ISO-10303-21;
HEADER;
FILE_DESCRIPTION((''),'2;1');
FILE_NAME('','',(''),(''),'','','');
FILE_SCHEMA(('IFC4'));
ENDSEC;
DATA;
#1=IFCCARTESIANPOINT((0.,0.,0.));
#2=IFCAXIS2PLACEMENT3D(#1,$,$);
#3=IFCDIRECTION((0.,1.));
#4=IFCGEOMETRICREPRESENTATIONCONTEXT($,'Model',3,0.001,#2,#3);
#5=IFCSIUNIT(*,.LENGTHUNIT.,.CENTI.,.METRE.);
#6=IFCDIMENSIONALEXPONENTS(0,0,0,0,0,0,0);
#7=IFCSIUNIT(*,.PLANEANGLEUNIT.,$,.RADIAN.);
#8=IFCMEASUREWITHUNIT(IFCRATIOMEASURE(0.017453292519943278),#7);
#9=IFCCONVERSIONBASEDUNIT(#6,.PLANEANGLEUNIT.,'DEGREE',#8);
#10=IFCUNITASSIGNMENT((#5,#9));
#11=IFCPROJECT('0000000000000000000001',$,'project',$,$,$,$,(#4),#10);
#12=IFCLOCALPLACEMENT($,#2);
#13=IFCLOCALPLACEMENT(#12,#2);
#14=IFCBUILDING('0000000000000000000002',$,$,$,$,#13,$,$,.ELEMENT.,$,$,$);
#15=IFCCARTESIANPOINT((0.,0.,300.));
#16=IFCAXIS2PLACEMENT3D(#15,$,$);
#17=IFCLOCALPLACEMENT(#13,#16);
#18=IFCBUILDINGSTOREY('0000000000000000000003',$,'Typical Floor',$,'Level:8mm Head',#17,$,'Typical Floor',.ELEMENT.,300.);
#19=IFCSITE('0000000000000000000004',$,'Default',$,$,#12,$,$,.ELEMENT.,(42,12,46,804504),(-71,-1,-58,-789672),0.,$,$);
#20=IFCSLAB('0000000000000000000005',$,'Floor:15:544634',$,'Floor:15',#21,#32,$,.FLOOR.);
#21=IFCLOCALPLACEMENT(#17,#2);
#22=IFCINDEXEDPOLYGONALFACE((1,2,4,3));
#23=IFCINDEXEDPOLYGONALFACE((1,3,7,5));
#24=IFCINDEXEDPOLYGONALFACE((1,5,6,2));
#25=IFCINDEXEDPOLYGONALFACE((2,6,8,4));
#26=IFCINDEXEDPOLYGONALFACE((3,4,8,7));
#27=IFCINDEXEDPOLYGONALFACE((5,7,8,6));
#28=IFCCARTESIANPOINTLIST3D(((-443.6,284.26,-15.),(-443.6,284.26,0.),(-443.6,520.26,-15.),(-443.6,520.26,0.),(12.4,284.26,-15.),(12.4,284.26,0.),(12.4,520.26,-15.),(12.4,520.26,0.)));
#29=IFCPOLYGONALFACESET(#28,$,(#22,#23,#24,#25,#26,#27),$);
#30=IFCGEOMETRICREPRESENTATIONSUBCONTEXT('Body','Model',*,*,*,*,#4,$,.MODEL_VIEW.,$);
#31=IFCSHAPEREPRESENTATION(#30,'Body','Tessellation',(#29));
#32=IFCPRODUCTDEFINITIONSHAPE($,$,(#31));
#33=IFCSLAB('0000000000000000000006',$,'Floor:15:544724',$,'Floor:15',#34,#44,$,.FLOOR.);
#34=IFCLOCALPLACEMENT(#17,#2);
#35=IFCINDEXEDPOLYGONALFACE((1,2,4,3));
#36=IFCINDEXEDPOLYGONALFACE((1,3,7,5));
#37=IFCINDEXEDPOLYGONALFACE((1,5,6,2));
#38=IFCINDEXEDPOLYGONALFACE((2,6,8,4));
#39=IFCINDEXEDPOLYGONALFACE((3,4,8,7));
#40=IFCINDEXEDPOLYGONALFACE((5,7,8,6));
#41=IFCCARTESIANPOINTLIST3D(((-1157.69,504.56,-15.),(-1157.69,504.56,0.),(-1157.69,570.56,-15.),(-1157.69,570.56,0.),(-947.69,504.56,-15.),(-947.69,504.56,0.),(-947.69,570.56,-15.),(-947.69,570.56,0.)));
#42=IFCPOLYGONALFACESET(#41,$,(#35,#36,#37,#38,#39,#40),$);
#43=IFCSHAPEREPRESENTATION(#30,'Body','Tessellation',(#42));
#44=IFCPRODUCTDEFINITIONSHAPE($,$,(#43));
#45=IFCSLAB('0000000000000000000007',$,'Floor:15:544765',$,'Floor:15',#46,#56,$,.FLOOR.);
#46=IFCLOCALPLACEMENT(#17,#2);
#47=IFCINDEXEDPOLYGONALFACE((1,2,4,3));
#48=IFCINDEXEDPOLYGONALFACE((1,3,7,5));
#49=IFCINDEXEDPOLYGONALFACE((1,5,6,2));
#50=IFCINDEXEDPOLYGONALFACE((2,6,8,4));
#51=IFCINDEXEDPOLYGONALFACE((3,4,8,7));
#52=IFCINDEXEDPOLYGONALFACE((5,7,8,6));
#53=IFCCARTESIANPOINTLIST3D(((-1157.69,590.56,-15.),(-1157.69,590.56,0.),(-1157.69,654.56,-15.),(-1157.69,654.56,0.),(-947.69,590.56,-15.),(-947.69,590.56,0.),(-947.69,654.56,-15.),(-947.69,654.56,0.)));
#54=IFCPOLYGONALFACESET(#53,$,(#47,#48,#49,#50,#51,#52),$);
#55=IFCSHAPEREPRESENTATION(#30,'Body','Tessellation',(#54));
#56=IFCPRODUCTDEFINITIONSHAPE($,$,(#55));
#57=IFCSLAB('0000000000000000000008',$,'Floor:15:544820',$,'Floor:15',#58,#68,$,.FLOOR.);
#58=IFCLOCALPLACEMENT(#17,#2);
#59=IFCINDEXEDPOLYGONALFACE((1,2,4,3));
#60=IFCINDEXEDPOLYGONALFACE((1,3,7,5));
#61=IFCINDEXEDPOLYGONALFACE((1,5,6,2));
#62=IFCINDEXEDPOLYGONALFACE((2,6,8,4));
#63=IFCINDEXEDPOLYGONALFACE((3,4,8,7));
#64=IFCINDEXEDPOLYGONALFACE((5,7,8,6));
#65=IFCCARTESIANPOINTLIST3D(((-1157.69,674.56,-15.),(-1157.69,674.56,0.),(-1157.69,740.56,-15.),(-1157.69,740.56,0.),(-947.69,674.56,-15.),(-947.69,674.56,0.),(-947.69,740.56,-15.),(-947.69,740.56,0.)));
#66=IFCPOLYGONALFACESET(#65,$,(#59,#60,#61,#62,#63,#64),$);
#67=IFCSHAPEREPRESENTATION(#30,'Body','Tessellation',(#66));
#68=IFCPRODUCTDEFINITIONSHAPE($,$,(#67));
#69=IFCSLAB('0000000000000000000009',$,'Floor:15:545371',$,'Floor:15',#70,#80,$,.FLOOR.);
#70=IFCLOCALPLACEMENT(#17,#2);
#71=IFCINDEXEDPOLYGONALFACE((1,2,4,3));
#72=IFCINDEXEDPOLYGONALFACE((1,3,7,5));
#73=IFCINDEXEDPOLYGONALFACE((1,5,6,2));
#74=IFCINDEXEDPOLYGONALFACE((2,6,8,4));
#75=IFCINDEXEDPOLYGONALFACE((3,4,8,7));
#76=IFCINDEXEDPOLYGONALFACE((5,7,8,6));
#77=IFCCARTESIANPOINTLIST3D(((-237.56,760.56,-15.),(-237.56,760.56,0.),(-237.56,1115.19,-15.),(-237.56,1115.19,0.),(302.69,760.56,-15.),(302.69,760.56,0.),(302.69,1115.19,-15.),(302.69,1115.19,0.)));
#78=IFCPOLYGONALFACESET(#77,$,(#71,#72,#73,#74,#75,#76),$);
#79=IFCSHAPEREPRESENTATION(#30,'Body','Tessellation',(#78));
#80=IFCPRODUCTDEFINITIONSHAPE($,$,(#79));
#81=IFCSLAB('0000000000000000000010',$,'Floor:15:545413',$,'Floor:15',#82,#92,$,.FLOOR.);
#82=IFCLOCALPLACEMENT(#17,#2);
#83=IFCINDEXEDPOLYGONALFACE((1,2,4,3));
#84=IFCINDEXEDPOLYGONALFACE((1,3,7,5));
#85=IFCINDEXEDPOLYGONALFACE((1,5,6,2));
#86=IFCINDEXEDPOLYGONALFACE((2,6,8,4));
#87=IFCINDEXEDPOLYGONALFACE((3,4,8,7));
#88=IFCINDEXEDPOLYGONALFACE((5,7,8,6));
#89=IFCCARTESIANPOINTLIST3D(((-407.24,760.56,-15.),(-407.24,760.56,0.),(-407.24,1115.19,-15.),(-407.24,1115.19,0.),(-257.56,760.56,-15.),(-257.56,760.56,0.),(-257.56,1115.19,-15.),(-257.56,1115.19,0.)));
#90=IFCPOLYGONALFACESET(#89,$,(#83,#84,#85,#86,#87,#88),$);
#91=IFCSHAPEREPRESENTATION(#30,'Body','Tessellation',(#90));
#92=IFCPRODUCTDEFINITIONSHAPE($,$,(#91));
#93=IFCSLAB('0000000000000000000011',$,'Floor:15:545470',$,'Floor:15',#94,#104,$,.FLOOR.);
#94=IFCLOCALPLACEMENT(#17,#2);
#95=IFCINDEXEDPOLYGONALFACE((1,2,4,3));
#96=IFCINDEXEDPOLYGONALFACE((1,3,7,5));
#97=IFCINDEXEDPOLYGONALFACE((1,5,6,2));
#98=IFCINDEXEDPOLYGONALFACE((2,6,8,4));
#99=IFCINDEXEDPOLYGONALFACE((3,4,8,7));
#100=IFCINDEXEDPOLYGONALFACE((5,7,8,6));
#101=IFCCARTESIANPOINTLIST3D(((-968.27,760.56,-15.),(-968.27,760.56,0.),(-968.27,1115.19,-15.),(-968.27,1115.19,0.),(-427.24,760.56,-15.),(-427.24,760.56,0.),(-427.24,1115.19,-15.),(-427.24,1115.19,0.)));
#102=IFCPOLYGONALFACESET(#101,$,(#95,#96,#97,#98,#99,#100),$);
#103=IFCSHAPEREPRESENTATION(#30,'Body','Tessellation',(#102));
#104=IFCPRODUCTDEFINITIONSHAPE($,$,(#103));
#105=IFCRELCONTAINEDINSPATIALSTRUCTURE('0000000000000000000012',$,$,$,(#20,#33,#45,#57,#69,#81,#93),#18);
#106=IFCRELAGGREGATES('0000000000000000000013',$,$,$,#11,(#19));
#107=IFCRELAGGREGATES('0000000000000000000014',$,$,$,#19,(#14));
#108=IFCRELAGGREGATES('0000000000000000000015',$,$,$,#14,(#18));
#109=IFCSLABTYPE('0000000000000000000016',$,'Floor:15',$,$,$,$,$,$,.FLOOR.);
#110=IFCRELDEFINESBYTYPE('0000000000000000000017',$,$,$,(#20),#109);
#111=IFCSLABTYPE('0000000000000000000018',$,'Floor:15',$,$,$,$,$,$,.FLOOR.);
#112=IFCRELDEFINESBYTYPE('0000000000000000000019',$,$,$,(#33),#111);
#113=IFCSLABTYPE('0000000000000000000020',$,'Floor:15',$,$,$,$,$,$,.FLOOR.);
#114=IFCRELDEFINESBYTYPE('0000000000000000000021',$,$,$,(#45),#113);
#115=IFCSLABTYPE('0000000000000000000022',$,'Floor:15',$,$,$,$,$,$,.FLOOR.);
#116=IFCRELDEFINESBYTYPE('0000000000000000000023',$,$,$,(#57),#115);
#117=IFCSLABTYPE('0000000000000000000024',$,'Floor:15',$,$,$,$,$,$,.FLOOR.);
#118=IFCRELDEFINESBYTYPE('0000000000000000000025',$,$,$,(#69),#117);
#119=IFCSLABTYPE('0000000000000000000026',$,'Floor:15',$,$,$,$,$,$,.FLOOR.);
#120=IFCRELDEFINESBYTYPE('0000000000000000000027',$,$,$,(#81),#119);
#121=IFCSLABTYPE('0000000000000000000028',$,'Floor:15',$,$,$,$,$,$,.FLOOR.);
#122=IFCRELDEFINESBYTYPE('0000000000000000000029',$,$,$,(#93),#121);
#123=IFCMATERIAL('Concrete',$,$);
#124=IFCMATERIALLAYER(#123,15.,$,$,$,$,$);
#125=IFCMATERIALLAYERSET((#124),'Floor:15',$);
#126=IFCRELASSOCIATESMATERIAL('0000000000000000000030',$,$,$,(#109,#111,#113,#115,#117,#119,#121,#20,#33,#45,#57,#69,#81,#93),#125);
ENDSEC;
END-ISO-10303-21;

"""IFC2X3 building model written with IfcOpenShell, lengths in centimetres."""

from ifc_helpers import new_model, entity, si_unit, converted_unit, direction, frame, frame_2d, origin, origin_2d_with_axis, place, context, subcontext, project, spatial, rectangle, extrude, material, layer, layer_set, layer_usage, type_object, element, save


model = new_model("IFC2X3")

# Units and contexts
model_context = context("Model", 3, precision=0.001, world=origin(), true_north=direction((0.0, 1.0)))
body_context = subcontext(model_context, "Body", "Model", "MODEL_VIEW")
ifc_project = project(units=[si_unit("LENGTHUNIT", "METRE", prefix="CENTI"), converted_unit("PLANEANGLEUNIT", "DEGREE", entity("IfcRatioMeasure", 0.017453292519943278), si_unit("PLANEANGLEUNIT", "RADIAN"), dimensions=[0, 0, 0, 0, 0, 0, 0])], contexts=[model_context])

# Site, building, storey
site_placement = place(None, origin())
site = spatial("IfcSite", under=ifc_project, at=site_placement, Name="Default", CompositionType="ELEMENT", RefLatitude=(42, 12, 46, 804504), RefLongitude=(-71, -1, -58, -789672), RefElevation=0.0)
building_placement = place(site_placement, origin())
building = spatial("IfcBuilding", under=site, at=building_placement, CompositionType="ELEMENT")
storey_placement = place(building_placement, frame((0.0, 0.0, 300.0)))
storey = spatial("IfcBuildingStorey", under=building, at=storey_placement, Name="Typical Floor", ObjectType="Level:8mm Head", LongName="Typical Floor", CompositionType="ELEMENT", Elevation=300.0)

# Shared definitions
ifc_material = material(Name="Concrete")

# Slabs
ifc_layer = layer(ifc_material, 15.0)
ifc_layer_set = layer_set([ifc_layer], Name="Floor:15")
ifc_layer_usage_1 = layer_usage(ifc_layer_set, "AXIS3", "POSITIVE", 0.0)
slab_type_1 = type_object("IfcSlabType", Name="Floor:15", PredefinedType="FLOOR", material=ifc_layer_set)
slab_1_placement = place(storey_placement, origin())
element("IfcSlab", 1, at=slab_1_placement, inside=storey, type_object=slab_type_1, material=ifc_layer_usage_1, Name="Floor:15:544634", ObjectType="Floor:15", PredefinedType="FLOOR", context=body_context, shape_type="SweptSolid", body=[
    extrude(rectangle(XDim=236.0, YDim=456.0, at=origin_2d_with_axis()), frame((-215.6, 402.26, 0.0), z_axis=(0.0, 0.0, -1.0), x_axis=(0.0, 1.0, 0.0)), (0.0, 0.0, 1.0), 15.0),
])
ifc_layer_usage_2 = layer_usage(ifc_layer_set, "AXIS3", "POSITIVE", 0.0)
slab_type_2 = type_object("IfcSlabType", Name="Floor:15", PredefinedType="FLOOR", material=ifc_layer_set)
slab_2_placement = place(storey_placement, origin())
element("IfcSlab", 2, at=slab_2_placement, inside=storey, type_object=slab_type_2, material=ifc_layer_usage_2, Name="Floor:15:544724", ObjectType="Floor:15", PredefinedType="FLOOR", context=body_context, shape_type="SweptSolid", body=[
    extrude(rectangle(XDim=66.0, YDim=210.0, at=frame_2d((0.0, 0.0), x_axis=(1.0, 0.0))), frame((-1052.69, 537.56, 0.0), z_axis=(0.0, 0.0, -1.0), x_axis=(0.0, 1.0, 0.0)), (0.0, 0.0, 1.0), 15.0),
])
ifc_layer_usage_3 = layer_usage(ifc_layer_set, "AXIS3", "POSITIVE", 0.0)
slab_type_3 = type_object("IfcSlabType", Name="Floor:15", PredefinedType="FLOOR", material=ifc_layer_set)
slab_3_placement = place(storey_placement, origin())
element("IfcSlab", 3, at=slab_3_placement, inside=storey, type_object=slab_type_3, material=ifc_layer_usage_3, Name="Floor:15:544765", ObjectType="Floor:15", PredefinedType="FLOOR", context=body_context, shape_type="SweptSolid", body=[
    extrude(rectangle(XDim=64.0, YDim=210.0, at=frame_2d((0.0, 0.0), x_axis=(1.0, 0.0))), frame((-1052.69, 622.56, 0.0), z_axis=(0.0, 0.0, -1.0), x_axis=(0.0, 1.0, 0.0)), (0.0, 0.0, 1.0), 15.0),
])
ifc_layer_usage_4 = layer_usage(ifc_layer_set, "AXIS3", "POSITIVE", 0.0)
slab_type_4 = type_object("IfcSlabType", Name="Floor:15", PredefinedType="FLOOR", material=ifc_layer_set)
slab_4_placement = place(storey_placement, origin())
element("IfcSlab", 4, at=slab_4_placement, inside=storey, type_object=slab_type_4, material=ifc_layer_usage_4, Name="Floor:15:544820", ObjectType="Floor:15", PredefinedType="FLOOR", context=body_context, shape_type="SweptSolid", body=[
    extrude(rectangle(XDim=66.0, YDim=210.0, at=frame_2d((0.0, 0.0), x_axis=(1.0, 0.0))), frame((-1052.69, 707.56, 0.0), z_axis=(0.0, 0.0, -1.0), x_axis=(0.0, 1.0, 0.0)), (0.0, 0.0, 1.0), 15.0),
])
ifc_layer_usage_5 = layer_usage(ifc_layer_set, "AXIS3", "POSITIVE", 0.0)
slab_type_5 = type_object("IfcSlabType", Name="Floor:15", PredefinedType="FLOOR", material=ifc_layer_set)
slab_5_placement = place(storey_placement, origin())
element("IfcSlab", 5, at=slab_5_placement, inside=storey, type_object=slab_type_5, material=ifc_layer_usage_5, Name="Floor:15:545371", ObjectType="Floor:15", PredefinedType="FLOOR", context=body_context, shape_type="SweptSolid", body=[
    extrude(rectangle(XDim=354.64, YDim=540.25, at=origin_2d_with_axis()), frame((32.57, 937.87, 0.0), z_axis=(0.0, 0.0, -1.0), x_axis=(0.0, 1.0, 0.0)), (0.0, 0.0, 1.0), 15.0),
])
ifc_layer_usage_6 = layer_usage(ifc_layer_set, "AXIS3", "POSITIVE", 0.0)
slab_type_6 = type_object("IfcSlabType", Name="Floor:15", PredefinedType="FLOOR", material=ifc_layer_set)
slab_6_placement = place(storey_placement, origin())
element("IfcSlab", 6, at=slab_6_placement, inside=storey, type_object=slab_type_6, material=ifc_layer_usage_6, Name="Floor:15:545413", ObjectType="Floor:15", PredefinedType="FLOOR", context=body_context, shape_type="SweptSolid", body=[
    extrude(rectangle(XDim=354.64, YDim=149.68, at=origin_2d_with_axis()), frame((-332.4, 937.87, 0.0), z_axis=(0.0, 0.0, -1.0), x_axis=(0.0, 1.0, 0.0)), (0.0, 0.0, 1.0), 15.0),
])
ifc_layer_usage_7 = layer_usage(ifc_layer_set, "AXIS3", "POSITIVE", 0.0)
slab_type_7 = type_object("IfcSlabType", Name="Floor:15", PredefinedType="FLOOR", material=ifc_layer_set)
slab_7_placement = place(storey_placement, origin())
element("IfcSlab", 7, at=slab_7_placement, inside=storey, type_object=slab_type_7, material=ifc_layer_usage_7, Name="Floor:15:545470", ObjectType="Floor:15", PredefinedType="FLOOR", context=body_context, shape_type="SweptSolid", body=[
    extrude(rectangle(XDim=354.64, YDim=541.03, at=frame_2d((0.0, 0.0), x_axis=(1.0, 0.0))), frame((-697.75, 937.87, 0.0), z_axis=(0.0, 0.0, -1.0), x_axis=(0.0, 1.0, 0.0)), (0.0, 0.0, 1.0), 15.0),
])

save(model, "model.ifc")
